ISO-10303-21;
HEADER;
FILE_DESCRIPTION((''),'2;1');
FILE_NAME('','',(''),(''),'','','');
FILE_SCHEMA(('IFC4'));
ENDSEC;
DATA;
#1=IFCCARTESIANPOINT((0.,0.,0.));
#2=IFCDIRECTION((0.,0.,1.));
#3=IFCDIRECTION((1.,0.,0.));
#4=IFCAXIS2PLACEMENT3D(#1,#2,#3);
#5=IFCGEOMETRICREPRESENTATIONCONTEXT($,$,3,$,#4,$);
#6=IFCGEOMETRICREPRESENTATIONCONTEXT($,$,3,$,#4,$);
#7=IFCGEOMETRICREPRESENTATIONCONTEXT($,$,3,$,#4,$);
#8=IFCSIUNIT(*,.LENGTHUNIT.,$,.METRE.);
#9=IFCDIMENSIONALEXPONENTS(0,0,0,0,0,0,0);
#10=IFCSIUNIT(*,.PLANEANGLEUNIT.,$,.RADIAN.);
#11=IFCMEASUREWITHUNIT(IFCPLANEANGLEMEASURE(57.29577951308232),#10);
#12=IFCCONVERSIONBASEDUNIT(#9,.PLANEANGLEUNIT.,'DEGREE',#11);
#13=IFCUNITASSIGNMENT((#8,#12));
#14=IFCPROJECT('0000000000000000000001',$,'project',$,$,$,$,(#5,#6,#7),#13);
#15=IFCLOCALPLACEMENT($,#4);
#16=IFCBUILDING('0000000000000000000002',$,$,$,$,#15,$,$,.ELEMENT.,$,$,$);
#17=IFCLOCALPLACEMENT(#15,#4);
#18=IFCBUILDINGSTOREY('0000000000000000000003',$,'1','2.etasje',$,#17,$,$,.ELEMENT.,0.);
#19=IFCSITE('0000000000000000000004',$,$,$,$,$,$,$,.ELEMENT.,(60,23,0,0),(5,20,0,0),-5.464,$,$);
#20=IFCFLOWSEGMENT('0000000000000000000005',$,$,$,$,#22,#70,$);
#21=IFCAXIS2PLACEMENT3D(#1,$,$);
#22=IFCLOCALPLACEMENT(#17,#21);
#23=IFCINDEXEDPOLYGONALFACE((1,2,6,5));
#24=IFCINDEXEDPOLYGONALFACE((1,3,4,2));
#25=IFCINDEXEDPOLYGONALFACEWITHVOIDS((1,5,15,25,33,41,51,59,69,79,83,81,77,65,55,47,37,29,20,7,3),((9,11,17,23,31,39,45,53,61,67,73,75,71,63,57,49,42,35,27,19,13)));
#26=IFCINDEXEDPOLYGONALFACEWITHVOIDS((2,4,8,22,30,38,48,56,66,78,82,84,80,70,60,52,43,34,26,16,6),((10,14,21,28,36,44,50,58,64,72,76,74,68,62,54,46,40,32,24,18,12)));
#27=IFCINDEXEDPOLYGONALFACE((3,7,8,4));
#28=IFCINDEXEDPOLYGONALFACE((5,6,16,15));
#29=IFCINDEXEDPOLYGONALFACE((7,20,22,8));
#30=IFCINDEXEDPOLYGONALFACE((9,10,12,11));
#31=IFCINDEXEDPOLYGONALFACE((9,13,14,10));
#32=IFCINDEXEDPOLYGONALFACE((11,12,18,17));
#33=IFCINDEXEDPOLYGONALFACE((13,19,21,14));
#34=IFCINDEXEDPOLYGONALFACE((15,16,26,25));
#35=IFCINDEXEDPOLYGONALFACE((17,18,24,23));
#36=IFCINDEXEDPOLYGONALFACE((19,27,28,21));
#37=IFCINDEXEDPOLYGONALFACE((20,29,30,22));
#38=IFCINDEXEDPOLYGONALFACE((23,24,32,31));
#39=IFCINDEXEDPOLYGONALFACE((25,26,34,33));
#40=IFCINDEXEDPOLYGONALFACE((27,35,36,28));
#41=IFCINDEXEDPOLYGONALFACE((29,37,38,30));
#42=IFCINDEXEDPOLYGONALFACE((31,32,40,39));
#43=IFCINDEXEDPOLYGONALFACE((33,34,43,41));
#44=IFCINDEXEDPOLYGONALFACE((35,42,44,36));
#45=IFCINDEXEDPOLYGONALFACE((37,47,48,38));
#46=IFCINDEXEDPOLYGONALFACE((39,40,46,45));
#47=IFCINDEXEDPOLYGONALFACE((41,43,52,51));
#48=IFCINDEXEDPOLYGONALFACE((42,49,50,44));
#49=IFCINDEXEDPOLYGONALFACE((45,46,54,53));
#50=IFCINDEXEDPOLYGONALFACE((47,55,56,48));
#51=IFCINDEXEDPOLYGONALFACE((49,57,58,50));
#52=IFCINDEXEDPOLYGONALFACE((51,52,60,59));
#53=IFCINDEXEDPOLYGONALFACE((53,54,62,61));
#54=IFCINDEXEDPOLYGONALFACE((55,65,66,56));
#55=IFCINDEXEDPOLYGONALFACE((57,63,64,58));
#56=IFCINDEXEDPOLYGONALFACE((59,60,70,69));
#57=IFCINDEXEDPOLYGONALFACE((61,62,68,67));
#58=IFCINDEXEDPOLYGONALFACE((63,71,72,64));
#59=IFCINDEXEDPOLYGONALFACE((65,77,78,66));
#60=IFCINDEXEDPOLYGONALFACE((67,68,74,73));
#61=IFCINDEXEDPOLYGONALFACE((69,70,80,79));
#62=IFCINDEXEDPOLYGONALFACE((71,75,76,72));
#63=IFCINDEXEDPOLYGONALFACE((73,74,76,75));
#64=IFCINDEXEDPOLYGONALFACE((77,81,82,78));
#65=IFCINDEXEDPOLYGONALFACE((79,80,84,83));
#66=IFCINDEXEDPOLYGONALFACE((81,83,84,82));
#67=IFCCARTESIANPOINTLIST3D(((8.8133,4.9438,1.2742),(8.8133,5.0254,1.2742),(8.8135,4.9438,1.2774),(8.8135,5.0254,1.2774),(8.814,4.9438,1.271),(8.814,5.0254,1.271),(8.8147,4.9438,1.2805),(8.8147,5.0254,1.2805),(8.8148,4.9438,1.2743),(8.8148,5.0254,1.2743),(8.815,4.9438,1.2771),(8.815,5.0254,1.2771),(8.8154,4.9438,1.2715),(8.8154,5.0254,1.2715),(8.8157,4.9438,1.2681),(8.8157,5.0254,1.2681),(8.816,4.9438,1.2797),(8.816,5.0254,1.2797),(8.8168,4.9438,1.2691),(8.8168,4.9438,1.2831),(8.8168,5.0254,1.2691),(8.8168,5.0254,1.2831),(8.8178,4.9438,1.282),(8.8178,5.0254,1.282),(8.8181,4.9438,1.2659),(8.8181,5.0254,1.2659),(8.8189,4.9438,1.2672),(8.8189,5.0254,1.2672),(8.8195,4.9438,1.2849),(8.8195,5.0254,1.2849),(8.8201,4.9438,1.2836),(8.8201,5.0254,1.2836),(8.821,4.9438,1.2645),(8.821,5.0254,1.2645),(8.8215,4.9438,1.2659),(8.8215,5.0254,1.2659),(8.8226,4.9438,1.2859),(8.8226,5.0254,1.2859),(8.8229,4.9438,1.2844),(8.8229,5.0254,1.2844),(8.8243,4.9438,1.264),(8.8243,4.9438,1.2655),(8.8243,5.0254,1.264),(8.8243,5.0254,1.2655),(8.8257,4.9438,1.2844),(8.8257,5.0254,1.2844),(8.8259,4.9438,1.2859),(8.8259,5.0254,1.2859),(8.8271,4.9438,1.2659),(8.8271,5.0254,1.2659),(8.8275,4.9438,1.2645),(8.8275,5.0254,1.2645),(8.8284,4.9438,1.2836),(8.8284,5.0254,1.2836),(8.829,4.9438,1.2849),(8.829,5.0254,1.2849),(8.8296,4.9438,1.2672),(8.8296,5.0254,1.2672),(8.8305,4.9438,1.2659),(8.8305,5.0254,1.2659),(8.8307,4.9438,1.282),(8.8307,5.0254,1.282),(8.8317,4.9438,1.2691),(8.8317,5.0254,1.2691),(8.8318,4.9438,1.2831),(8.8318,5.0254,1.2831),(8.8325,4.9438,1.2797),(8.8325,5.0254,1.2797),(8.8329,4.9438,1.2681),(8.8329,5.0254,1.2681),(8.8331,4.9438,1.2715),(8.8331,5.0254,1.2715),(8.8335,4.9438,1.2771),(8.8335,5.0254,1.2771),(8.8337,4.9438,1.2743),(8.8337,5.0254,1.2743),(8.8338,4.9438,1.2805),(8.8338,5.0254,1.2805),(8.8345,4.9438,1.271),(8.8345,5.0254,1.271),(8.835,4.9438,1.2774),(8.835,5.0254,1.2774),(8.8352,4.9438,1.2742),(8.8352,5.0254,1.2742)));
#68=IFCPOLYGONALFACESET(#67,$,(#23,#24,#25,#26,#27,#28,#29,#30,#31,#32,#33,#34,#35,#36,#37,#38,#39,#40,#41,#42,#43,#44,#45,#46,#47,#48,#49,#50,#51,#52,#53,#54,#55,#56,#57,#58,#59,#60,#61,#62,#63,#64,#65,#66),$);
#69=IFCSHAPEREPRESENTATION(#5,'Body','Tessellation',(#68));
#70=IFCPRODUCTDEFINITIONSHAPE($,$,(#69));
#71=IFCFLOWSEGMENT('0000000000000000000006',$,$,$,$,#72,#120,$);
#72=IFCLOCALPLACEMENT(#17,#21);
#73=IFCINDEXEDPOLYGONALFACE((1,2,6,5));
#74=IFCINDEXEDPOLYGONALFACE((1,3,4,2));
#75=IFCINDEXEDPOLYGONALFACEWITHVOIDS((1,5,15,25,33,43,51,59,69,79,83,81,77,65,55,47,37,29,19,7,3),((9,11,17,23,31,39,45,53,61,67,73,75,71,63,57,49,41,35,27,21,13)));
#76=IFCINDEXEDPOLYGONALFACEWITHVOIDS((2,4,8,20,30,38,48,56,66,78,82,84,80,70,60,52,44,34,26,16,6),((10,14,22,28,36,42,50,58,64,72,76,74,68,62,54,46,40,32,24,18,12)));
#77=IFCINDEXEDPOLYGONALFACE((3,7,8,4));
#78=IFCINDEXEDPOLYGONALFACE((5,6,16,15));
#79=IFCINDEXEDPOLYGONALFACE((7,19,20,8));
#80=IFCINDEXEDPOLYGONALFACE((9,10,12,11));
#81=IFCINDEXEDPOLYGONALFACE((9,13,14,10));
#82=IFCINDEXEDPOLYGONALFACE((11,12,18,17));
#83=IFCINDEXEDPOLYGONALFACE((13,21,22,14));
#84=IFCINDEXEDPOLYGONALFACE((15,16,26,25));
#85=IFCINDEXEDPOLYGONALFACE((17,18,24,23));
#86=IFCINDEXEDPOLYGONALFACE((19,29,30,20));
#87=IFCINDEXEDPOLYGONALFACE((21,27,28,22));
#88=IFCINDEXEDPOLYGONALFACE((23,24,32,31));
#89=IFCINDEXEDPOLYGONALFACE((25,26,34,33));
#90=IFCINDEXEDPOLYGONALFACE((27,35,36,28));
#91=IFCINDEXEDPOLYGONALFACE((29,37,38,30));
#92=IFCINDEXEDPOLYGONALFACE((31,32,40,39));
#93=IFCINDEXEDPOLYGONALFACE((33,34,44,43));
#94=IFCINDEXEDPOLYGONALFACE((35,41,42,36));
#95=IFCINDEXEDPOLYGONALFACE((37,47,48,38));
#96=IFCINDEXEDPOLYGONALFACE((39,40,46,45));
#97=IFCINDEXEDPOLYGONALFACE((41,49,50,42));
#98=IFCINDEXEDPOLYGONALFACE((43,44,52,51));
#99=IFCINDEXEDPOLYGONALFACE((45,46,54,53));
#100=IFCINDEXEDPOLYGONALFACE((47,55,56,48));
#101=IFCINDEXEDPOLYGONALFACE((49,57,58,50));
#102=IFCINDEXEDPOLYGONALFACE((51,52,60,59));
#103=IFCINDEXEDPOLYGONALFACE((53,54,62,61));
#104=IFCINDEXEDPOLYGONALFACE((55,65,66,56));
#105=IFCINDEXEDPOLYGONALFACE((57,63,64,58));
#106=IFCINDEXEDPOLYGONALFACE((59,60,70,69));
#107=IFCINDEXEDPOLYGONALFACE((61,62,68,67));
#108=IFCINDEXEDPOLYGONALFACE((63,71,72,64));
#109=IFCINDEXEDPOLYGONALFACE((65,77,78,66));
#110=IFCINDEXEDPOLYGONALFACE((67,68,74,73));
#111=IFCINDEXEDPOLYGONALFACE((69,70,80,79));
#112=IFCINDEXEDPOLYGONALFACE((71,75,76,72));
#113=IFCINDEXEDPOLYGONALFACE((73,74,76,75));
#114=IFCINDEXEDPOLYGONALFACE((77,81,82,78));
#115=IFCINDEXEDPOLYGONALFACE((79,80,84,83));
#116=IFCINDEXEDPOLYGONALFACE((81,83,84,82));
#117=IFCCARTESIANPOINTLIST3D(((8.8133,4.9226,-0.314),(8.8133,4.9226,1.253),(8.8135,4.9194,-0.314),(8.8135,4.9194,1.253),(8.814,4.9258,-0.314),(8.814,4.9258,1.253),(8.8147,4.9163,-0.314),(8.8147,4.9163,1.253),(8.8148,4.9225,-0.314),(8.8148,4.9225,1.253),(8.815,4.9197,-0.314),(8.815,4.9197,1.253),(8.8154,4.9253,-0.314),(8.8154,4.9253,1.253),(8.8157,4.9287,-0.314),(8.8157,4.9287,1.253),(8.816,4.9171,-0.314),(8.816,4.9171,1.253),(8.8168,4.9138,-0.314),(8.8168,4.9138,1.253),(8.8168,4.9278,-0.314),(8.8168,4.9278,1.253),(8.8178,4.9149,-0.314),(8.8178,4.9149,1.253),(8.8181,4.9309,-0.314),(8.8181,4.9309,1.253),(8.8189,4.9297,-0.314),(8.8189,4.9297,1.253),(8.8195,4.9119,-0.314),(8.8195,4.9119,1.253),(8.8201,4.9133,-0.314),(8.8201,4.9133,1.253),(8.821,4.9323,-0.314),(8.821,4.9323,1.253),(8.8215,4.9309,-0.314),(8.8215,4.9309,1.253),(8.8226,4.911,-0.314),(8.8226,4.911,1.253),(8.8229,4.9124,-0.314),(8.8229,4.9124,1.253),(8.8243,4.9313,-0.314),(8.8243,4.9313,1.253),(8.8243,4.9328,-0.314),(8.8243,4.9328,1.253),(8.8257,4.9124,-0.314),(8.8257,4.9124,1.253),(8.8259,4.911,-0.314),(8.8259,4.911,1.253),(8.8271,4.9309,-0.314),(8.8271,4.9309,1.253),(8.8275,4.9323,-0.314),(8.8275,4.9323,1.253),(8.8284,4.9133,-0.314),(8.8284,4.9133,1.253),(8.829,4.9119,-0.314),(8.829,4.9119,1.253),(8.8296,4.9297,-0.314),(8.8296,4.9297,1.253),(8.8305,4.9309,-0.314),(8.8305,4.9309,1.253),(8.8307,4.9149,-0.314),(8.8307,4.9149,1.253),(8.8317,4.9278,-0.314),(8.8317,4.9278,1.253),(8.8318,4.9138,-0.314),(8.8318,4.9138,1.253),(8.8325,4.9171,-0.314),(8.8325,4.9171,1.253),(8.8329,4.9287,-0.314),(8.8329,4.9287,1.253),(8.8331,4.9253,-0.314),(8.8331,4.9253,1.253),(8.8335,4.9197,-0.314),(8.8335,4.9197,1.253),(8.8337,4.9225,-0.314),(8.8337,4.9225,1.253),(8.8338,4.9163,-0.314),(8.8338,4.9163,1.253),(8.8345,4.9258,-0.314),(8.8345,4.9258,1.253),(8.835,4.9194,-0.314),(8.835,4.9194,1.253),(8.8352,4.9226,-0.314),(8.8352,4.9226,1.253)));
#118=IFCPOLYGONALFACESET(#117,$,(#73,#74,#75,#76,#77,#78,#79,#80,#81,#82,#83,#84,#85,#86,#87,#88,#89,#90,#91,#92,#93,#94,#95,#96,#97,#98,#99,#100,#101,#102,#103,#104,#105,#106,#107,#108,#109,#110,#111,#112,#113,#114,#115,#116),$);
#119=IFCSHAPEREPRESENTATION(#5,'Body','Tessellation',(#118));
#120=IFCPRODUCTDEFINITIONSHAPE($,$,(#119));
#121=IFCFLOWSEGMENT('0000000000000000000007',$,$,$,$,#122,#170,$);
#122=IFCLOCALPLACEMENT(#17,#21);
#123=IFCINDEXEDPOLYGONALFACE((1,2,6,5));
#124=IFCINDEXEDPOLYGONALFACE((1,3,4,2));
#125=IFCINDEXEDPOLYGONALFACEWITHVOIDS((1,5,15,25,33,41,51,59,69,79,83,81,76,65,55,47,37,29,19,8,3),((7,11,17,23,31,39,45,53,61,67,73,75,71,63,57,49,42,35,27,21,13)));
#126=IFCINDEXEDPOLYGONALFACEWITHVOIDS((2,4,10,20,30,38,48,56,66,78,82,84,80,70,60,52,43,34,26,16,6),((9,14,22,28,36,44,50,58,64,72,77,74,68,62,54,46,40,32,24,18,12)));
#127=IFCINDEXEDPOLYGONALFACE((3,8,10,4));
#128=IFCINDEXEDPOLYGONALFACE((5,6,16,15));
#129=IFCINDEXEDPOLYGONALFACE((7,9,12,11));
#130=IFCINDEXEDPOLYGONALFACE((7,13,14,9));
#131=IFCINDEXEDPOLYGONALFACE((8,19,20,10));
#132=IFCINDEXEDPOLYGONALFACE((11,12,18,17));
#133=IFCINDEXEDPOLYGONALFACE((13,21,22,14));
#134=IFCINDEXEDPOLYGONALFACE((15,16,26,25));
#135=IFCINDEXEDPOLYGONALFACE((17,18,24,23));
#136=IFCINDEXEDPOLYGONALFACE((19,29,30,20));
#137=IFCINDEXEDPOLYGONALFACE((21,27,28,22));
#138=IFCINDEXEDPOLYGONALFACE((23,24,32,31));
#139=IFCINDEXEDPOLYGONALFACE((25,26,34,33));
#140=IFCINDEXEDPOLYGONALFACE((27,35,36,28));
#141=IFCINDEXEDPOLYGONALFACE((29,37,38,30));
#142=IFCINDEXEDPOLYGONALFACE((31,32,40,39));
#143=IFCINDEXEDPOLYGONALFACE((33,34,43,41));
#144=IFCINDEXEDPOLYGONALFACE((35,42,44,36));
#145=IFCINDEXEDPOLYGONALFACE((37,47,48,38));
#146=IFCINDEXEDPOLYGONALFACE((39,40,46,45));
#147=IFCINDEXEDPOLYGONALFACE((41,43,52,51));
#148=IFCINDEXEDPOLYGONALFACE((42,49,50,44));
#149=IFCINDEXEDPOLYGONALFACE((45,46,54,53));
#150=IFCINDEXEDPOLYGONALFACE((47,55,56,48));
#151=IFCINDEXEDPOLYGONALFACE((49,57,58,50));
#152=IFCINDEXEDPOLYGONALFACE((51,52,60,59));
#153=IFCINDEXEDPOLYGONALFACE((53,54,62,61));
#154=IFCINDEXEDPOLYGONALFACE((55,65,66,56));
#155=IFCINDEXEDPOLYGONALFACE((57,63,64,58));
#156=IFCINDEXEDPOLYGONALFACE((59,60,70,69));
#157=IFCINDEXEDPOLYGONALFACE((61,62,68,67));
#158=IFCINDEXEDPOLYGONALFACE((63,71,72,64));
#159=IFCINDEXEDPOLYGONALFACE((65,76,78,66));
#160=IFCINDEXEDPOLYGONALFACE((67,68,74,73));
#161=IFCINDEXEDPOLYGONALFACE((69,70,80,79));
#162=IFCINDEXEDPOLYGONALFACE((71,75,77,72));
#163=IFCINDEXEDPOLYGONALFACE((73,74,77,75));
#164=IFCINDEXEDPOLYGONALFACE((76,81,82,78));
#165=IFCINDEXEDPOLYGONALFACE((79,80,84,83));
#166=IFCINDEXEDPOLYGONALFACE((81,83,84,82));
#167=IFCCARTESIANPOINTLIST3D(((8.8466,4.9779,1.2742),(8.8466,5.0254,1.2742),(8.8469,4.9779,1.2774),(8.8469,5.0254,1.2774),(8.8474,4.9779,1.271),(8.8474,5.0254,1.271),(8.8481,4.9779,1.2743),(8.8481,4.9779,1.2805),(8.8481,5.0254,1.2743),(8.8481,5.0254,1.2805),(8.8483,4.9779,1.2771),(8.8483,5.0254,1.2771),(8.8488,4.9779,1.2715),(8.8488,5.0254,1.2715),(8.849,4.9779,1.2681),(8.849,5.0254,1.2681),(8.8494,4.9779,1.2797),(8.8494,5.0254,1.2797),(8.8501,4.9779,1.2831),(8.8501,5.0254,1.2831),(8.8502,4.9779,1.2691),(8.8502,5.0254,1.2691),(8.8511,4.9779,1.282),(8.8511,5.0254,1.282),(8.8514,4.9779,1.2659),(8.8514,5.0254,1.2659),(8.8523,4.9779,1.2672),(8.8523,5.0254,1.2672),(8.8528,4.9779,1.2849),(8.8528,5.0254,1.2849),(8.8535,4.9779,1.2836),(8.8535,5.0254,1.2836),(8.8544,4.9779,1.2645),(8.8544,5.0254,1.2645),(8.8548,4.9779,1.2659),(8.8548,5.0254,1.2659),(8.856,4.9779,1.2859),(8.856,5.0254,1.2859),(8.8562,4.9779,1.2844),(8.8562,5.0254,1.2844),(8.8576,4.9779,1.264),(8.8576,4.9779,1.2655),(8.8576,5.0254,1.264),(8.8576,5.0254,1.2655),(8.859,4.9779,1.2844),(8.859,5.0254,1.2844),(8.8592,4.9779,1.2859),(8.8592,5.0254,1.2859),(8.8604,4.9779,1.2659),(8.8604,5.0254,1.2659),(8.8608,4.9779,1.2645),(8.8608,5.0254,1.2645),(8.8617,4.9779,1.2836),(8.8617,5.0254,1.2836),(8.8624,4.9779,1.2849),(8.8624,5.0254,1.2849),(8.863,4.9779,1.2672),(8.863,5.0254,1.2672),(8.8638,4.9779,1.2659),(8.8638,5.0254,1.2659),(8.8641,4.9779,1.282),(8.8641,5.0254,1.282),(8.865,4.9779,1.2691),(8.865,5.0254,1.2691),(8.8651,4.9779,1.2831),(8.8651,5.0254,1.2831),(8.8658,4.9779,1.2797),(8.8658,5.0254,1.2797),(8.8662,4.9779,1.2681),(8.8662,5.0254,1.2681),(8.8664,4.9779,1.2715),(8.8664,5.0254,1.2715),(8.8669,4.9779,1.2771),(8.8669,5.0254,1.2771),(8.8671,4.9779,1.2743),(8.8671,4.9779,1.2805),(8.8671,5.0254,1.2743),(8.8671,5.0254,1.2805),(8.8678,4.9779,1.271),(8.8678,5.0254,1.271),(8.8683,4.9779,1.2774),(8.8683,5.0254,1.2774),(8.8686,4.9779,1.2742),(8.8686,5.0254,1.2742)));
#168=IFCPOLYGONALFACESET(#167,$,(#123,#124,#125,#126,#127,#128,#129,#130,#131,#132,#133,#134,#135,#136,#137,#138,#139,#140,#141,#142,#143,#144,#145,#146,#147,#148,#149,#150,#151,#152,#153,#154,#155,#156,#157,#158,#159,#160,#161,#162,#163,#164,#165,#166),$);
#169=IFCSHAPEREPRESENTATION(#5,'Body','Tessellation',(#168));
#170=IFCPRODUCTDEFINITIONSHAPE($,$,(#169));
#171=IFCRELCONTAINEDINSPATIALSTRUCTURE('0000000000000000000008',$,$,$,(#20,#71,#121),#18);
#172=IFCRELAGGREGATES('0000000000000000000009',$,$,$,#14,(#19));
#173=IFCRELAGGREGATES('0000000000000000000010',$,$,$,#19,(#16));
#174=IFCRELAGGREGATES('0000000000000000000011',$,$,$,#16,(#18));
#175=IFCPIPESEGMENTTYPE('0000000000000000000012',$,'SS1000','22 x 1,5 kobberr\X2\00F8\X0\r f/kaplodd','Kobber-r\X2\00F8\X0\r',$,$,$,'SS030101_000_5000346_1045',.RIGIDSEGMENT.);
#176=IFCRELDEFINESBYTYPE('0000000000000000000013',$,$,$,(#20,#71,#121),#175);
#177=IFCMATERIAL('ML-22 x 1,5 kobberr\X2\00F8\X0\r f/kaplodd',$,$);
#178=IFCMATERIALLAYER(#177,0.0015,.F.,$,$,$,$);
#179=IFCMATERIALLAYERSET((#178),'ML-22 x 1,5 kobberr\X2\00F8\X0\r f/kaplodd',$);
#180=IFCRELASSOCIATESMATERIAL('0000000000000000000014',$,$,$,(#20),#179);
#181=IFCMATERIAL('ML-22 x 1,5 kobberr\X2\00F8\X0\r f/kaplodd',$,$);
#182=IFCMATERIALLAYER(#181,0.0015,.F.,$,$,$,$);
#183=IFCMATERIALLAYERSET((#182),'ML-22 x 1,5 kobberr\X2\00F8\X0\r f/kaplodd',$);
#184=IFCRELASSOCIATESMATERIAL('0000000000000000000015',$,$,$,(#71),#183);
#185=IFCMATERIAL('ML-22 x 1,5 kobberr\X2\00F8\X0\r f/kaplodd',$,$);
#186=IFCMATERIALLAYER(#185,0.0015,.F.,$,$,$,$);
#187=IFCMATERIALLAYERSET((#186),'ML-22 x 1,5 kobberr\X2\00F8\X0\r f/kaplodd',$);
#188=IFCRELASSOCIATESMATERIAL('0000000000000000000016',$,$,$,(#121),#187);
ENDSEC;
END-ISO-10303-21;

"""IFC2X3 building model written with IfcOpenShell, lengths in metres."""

from ifc_helpers import new_model, entity, si_unit, converted_unit, frame, origin_with_axes, origin_2d_with_axis, place, context, project, spatial, hollow_circle, extrude, material, layer, layer_set, layer_usage, type_object, element, save


model = new_model("IFC2X3")

# Units and contexts
context_of_model_1 = context(None, 3, world=origin_with_axes())
context_of_model_2 = context(None, 3, world=origin_with_axes())
context_of_model_3 = context(None, 3, world=origin_with_axes())
ifc_project = project(units=[si_unit("LENGTHUNIT", "METRE"), converted_unit("PLANEANGLEUNIT", "DEGREE", entity("IfcPlaneAngleMeasure", 57.29577951308232), si_unit("PLANEANGLEUNIT", "RADIAN"), dimensions=[0, 0, 0, 0, 0, 0, 0])], contexts=[context_of_model_1, context_of_model_2, context_of_model_3])

# Site, building, storey
site = spatial("IfcSite", under=ifc_project, CompositionType="ELEMENT", RefLatitude=(60, 23, 0, 0), RefLongitude=(5, 20, 0, 0), RefElevation=-5.464)
building_placement = place(None, origin_with_axes())
building = spatial("IfcBuilding", under=site, at=building_placement, CompositionType="ELEMENT")
storey_placement = place(building_placement, origin_with_axes())
storey = spatial("IfcBuildingStorey", under=building, at=storey_placement, Name="1", Description="2.etasje", CompositionType="ELEMENT", Elevation=0.0)

# Flow segments
ifc_material_1 = material(Name="ML-22 x 1,5 kobberrør f/kaplodd")
ifc_layer_1 = layer(ifc_material_1, 0.0015, ventilated=False)
ifc_layer_set_1 = layer_set([ifc_layer_1], Name="ML-22 x 1,5 kobberrør f/kaplodd")
ifc_layer_usage_1 = layer_usage(ifc_layer_set_1, "AXIS2", "POSITIVE", 0.0)
pipe_segment_type_1 = type_object("IfcPipeSegmentType", Name="SS1000", Description="22 x 1,5 kobberrør f/kaplodd", ApplicableOccurrence="Kobber-rør", ElementType="SS030101_000_5000346_1045", PredefinedType="RIGIDSEGMENT")
flow_segment_1_placement = place(storey_placement, frame((8.8243, 5.0254, 1.275), z_axis=(0.0, -1.0, 0.0), x_axis=(0.0, 0.0, -1.0)))
element("IfcFlowSegment", 1, at=flow_segment_1_placement, inside=storey, type_object=pipe_segment_type_1, material=ifc_layer_usage_1, context=context_of_model_1, shape_type="SweptSolid", body=[
    extrude(hollow_circle(Radius=0.011, WallThickness=0.0015, at=origin_2d_with_axis()), origin_with_axes(), (0.0, 0.0, 1.0), 0.0816),
])
ifc_material_2 = material(Name="ML-22 x 1,5 kobberrør f/kaplodd")
ifc_layer_2 = layer(ifc_material_2, 0.0015, ventilated=False)
ifc_layer_set_2 = layer_set([ifc_layer_2], Name="ML-22 x 1,5 kobberrør f/kaplodd")
ifc_layer_usage_2 = layer_usage(ifc_layer_set_2, "AXIS2", "POSITIVE", 0.0)
flow_segment_2_placement = place(storey_placement, frame((8.8243, 4.9218, 1.253), z_axis=(0.0, 0.0, -1.0), x_axis=(0.0, 1.0, 0.0)))
element("IfcFlowSegment", 2, at=flow_segment_2_placement, inside=storey, type_object=pipe_segment_type_1, material=ifc_layer_usage_2, context=context_of_model_1, shape_type="SweptSolid", body=[
    extrude(hollow_circle(Radius=0.011, WallThickness=0.0015, at=origin_2d_with_axis()), origin_with_axes(), (0.0, 0.0, 1.0), 1.567),
])
ifc_material_3 = material(Name="ML-22 x 1,5 kobberrør f/kaplodd")
ifc_layer_3 = layer(ifc_material_3, 0.0015, ventilated=False)
ifc_layer_set_3 = layer_set([ifc_layer_3], Name="ML-22 x 1,5 kobberrør f/kaplodd")
ifc_layer_usage_3 = layer_usage(ifc_layer_set_3, "AXIS2", "POSITIVE", 0.0)
flow_segment_3_placement = place(storey_placement, frame((8.8576, 5.0254, 1.275), z_axis=(0.0, -1.0, 0.0), x_axis=(0.0, 0.0, -1.0)))
element("IfcFlowSegment", 3, at=flow_segment_3_placement, inside=storey, type_object=pipe_segment_type_1, material=ifc_layer_usage_3, context=context_of_model_1, shape_type="SweptSolid", body=[
    extrude(hollow_circle(Radius=0.011, WallThickness=0.0015, at=origin_2d_with_axis()), origin_with_axes(), (0.0, 0.0, 1.0), 0.0475),
])

save(model, "model.ifc")
